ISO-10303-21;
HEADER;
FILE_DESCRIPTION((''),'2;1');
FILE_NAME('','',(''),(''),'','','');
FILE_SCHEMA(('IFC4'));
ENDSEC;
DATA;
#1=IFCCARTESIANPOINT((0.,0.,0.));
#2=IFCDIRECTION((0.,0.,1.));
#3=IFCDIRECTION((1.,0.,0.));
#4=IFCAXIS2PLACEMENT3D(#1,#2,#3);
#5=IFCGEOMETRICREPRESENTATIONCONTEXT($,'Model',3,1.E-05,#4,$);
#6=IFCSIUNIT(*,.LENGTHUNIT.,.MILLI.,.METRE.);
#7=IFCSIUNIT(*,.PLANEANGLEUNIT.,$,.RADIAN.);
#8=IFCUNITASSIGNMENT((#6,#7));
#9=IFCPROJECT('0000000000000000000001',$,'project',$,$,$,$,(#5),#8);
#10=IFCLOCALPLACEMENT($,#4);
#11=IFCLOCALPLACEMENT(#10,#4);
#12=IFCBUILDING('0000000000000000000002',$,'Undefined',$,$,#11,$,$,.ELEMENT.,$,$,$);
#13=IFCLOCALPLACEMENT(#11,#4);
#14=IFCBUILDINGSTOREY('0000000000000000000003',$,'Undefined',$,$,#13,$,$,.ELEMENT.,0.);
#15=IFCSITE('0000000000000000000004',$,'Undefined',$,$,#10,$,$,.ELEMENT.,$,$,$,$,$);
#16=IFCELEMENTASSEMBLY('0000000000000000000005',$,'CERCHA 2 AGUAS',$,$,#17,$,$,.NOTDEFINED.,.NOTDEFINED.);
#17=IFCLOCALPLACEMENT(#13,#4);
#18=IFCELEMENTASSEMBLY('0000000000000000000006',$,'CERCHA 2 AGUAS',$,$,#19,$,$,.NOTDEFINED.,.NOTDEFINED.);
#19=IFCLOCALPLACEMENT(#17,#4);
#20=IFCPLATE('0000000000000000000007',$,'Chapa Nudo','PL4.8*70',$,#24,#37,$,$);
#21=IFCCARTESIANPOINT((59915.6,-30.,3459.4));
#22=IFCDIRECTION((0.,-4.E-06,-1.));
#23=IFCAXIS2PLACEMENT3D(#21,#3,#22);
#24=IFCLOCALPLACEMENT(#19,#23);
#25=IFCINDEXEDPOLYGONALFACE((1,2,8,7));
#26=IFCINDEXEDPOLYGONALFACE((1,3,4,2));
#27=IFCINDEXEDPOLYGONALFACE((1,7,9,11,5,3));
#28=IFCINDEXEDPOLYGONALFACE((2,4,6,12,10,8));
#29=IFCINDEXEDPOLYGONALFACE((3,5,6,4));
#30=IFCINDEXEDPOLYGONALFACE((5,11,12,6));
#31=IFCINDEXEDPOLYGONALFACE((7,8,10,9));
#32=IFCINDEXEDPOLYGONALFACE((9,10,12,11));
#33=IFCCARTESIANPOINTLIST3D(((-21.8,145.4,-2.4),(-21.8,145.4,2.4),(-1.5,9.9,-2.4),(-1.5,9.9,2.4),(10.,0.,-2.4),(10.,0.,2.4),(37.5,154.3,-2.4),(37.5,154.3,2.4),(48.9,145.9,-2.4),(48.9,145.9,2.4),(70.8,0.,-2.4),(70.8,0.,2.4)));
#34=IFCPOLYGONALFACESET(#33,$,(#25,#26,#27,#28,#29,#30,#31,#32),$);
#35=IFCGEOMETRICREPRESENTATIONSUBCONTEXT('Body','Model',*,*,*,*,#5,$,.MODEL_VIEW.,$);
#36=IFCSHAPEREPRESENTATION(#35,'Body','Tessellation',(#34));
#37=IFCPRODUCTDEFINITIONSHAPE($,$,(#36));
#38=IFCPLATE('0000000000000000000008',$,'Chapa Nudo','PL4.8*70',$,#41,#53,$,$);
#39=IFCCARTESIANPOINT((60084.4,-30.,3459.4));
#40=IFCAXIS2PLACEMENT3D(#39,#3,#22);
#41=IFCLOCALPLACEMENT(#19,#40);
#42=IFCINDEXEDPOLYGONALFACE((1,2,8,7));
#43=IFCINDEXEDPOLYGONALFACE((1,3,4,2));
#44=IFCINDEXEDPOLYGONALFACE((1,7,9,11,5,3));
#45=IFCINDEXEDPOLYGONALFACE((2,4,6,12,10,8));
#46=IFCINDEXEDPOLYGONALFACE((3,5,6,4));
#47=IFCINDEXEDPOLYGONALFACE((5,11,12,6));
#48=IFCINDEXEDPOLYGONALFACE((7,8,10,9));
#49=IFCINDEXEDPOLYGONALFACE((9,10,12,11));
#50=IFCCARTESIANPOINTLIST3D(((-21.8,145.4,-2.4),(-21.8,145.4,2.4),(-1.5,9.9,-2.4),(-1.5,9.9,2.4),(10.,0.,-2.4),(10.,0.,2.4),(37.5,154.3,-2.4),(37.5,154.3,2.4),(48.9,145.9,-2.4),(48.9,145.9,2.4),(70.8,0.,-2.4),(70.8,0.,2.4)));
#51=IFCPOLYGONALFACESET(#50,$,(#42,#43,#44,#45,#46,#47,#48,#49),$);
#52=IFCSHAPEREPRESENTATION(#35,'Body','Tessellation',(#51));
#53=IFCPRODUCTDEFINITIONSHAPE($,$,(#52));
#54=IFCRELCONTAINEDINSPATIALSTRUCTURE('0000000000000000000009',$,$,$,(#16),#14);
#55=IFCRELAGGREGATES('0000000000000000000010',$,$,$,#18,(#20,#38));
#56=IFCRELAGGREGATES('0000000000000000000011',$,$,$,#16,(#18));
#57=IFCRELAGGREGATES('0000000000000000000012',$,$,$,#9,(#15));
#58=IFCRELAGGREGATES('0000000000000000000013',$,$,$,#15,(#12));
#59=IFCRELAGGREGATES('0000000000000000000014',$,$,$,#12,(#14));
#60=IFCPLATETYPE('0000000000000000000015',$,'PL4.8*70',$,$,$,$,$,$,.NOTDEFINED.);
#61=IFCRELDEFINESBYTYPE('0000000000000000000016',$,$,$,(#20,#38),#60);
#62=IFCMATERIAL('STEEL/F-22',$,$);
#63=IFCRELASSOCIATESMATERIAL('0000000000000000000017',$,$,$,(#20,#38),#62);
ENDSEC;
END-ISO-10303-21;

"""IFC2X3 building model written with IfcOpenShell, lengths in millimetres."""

from ifc_helpers import new_model, si_unit, frame, origin_with_axes, place, context, subcontext, project, spatial, polyline, outline, extrude, material, type_object, element, aggregate, save


model = new_model("IFC2X3")

# Units and contexts
model_context = context("Model", 3, precision=1e-05, world=origin_with_axes())
body_context = subcontext(model_context, "Body", "Model", "MODEL_VIEW")
ifc_project = project(units=[si_unit("LENGTHUNIT", "METRE", prefix="MILLI"), si_unit("PLANEANGLEUNIT", "RADIAN")], contexts=[model_context])

# Site, building, storey
site_placement = place(None, origin_with_axes())
site = spatial("IfcSite", under=ifc_project, at=site_placement, Name="Undefined", CompositionType="ELEMENT")
building_placement = place(site_placement, origin_with_axes())
building = spatial("IfcBuilding", under=site, at=building_placement, Name="Undefined", CompositionType="ELEMENT")
storey_placement = place(building_placement, origin_with_axes())
storey = spatial("IfcBuildingStorey", under=building, at=storey_placement, Name="Undefined", CompositionType="ELEMENT", Elevation=0.0)

# Element assemblies
assembly_1_placement = place(storey_placement, origin_with_axes())
assembly_1 = element("IfcElementAssembly", 1, at=assembly_1_placement, inside=storey, Name="CERCHA 2 AGUAS", AssemblyPlace="NOTDEFINED", PredefinedType="NOTDEFINED")
assembly_2_placement = place(assembly_1_placement, origin_with_axes())
assembly_2 = element("IfcElementAssembly", 2, at=assembly_2_placement, Name="CERCHA 2 AGUAS", AssemblyPlace="NOTDEFINED", PredefinedType="NOTDEFINED")
ifc_material_1 = material(Name="STEEL/F-22")

# Plates
plate_type_1 = type_object("IfcPlateType", Name="PL4.8*70", PredefinedType="NOTDEFINED")
plate_1_placement = place(assembly_2_placement, frame((59915.6, -30.0, 3459.4), z_axis=(1.0, 0.0, 0.0), x_axis=(0.0, -0.000004, -1.0)))
plate_1 = element("IfcPlate", 3, at=plate_1_placement, type_object=plate_type_1, material=ifc_material_1, Name="Chapa Nudo", Description="PL4.8*70", context=body_context, shape_type="SweptSolid", body=[
    extrude(outline(polyline([(-1.5, 9.9), (10.0, 0.0), (70.8, 0.0), (70.8, 0.0), (48.9, 145.9), (37.5, 154.3), (-21.8, 145.4), (-1.5, 9.9)])), frame((0.0, 0.0, -2.4), z_axis=(0.0, 0.0, 1.0), x_axis=(1.0, 0.0, 0.0)), (0.0, 0.0, 1.0), 4.8),
])
plate_2_placement = place(assembly_2_placement, frame((60084.4, -30.0, 3459.4), z_axis=(1.0, 0.0, 0.0), x_axis=(0.0, -0.000004, -1.0)))
plate_2 = element("IfcPlate", 4, at=plate_2_placement, type_object=plate_type_1, material=ifc_material_1, Name="Chapa Nudo", Description="PL4.8*70", context=body_context, shape_type="SweptSolid", body=[
    extrude(outline(polyline([(-1.5, 9.9), (10.0, 0.0), (70.8, 0.0), (70.8, 0.0), (48.9, 145.9), (37.5, 154.3), (-21.8, 145.4), (-1.5, 9.9)])), frame((0.0, 0.0, -2.4), z_axis=(0.0, 0.0, 1.0), x_axis=(1.0, 0.0, 0.0)), (0.0, 0.0, 1.0), 4.8),
])

aggregate(assembly_2, [plate_1, plate_2])

aggregate(assembly_1, [assembly_2])

save(model, "model.ifc")
